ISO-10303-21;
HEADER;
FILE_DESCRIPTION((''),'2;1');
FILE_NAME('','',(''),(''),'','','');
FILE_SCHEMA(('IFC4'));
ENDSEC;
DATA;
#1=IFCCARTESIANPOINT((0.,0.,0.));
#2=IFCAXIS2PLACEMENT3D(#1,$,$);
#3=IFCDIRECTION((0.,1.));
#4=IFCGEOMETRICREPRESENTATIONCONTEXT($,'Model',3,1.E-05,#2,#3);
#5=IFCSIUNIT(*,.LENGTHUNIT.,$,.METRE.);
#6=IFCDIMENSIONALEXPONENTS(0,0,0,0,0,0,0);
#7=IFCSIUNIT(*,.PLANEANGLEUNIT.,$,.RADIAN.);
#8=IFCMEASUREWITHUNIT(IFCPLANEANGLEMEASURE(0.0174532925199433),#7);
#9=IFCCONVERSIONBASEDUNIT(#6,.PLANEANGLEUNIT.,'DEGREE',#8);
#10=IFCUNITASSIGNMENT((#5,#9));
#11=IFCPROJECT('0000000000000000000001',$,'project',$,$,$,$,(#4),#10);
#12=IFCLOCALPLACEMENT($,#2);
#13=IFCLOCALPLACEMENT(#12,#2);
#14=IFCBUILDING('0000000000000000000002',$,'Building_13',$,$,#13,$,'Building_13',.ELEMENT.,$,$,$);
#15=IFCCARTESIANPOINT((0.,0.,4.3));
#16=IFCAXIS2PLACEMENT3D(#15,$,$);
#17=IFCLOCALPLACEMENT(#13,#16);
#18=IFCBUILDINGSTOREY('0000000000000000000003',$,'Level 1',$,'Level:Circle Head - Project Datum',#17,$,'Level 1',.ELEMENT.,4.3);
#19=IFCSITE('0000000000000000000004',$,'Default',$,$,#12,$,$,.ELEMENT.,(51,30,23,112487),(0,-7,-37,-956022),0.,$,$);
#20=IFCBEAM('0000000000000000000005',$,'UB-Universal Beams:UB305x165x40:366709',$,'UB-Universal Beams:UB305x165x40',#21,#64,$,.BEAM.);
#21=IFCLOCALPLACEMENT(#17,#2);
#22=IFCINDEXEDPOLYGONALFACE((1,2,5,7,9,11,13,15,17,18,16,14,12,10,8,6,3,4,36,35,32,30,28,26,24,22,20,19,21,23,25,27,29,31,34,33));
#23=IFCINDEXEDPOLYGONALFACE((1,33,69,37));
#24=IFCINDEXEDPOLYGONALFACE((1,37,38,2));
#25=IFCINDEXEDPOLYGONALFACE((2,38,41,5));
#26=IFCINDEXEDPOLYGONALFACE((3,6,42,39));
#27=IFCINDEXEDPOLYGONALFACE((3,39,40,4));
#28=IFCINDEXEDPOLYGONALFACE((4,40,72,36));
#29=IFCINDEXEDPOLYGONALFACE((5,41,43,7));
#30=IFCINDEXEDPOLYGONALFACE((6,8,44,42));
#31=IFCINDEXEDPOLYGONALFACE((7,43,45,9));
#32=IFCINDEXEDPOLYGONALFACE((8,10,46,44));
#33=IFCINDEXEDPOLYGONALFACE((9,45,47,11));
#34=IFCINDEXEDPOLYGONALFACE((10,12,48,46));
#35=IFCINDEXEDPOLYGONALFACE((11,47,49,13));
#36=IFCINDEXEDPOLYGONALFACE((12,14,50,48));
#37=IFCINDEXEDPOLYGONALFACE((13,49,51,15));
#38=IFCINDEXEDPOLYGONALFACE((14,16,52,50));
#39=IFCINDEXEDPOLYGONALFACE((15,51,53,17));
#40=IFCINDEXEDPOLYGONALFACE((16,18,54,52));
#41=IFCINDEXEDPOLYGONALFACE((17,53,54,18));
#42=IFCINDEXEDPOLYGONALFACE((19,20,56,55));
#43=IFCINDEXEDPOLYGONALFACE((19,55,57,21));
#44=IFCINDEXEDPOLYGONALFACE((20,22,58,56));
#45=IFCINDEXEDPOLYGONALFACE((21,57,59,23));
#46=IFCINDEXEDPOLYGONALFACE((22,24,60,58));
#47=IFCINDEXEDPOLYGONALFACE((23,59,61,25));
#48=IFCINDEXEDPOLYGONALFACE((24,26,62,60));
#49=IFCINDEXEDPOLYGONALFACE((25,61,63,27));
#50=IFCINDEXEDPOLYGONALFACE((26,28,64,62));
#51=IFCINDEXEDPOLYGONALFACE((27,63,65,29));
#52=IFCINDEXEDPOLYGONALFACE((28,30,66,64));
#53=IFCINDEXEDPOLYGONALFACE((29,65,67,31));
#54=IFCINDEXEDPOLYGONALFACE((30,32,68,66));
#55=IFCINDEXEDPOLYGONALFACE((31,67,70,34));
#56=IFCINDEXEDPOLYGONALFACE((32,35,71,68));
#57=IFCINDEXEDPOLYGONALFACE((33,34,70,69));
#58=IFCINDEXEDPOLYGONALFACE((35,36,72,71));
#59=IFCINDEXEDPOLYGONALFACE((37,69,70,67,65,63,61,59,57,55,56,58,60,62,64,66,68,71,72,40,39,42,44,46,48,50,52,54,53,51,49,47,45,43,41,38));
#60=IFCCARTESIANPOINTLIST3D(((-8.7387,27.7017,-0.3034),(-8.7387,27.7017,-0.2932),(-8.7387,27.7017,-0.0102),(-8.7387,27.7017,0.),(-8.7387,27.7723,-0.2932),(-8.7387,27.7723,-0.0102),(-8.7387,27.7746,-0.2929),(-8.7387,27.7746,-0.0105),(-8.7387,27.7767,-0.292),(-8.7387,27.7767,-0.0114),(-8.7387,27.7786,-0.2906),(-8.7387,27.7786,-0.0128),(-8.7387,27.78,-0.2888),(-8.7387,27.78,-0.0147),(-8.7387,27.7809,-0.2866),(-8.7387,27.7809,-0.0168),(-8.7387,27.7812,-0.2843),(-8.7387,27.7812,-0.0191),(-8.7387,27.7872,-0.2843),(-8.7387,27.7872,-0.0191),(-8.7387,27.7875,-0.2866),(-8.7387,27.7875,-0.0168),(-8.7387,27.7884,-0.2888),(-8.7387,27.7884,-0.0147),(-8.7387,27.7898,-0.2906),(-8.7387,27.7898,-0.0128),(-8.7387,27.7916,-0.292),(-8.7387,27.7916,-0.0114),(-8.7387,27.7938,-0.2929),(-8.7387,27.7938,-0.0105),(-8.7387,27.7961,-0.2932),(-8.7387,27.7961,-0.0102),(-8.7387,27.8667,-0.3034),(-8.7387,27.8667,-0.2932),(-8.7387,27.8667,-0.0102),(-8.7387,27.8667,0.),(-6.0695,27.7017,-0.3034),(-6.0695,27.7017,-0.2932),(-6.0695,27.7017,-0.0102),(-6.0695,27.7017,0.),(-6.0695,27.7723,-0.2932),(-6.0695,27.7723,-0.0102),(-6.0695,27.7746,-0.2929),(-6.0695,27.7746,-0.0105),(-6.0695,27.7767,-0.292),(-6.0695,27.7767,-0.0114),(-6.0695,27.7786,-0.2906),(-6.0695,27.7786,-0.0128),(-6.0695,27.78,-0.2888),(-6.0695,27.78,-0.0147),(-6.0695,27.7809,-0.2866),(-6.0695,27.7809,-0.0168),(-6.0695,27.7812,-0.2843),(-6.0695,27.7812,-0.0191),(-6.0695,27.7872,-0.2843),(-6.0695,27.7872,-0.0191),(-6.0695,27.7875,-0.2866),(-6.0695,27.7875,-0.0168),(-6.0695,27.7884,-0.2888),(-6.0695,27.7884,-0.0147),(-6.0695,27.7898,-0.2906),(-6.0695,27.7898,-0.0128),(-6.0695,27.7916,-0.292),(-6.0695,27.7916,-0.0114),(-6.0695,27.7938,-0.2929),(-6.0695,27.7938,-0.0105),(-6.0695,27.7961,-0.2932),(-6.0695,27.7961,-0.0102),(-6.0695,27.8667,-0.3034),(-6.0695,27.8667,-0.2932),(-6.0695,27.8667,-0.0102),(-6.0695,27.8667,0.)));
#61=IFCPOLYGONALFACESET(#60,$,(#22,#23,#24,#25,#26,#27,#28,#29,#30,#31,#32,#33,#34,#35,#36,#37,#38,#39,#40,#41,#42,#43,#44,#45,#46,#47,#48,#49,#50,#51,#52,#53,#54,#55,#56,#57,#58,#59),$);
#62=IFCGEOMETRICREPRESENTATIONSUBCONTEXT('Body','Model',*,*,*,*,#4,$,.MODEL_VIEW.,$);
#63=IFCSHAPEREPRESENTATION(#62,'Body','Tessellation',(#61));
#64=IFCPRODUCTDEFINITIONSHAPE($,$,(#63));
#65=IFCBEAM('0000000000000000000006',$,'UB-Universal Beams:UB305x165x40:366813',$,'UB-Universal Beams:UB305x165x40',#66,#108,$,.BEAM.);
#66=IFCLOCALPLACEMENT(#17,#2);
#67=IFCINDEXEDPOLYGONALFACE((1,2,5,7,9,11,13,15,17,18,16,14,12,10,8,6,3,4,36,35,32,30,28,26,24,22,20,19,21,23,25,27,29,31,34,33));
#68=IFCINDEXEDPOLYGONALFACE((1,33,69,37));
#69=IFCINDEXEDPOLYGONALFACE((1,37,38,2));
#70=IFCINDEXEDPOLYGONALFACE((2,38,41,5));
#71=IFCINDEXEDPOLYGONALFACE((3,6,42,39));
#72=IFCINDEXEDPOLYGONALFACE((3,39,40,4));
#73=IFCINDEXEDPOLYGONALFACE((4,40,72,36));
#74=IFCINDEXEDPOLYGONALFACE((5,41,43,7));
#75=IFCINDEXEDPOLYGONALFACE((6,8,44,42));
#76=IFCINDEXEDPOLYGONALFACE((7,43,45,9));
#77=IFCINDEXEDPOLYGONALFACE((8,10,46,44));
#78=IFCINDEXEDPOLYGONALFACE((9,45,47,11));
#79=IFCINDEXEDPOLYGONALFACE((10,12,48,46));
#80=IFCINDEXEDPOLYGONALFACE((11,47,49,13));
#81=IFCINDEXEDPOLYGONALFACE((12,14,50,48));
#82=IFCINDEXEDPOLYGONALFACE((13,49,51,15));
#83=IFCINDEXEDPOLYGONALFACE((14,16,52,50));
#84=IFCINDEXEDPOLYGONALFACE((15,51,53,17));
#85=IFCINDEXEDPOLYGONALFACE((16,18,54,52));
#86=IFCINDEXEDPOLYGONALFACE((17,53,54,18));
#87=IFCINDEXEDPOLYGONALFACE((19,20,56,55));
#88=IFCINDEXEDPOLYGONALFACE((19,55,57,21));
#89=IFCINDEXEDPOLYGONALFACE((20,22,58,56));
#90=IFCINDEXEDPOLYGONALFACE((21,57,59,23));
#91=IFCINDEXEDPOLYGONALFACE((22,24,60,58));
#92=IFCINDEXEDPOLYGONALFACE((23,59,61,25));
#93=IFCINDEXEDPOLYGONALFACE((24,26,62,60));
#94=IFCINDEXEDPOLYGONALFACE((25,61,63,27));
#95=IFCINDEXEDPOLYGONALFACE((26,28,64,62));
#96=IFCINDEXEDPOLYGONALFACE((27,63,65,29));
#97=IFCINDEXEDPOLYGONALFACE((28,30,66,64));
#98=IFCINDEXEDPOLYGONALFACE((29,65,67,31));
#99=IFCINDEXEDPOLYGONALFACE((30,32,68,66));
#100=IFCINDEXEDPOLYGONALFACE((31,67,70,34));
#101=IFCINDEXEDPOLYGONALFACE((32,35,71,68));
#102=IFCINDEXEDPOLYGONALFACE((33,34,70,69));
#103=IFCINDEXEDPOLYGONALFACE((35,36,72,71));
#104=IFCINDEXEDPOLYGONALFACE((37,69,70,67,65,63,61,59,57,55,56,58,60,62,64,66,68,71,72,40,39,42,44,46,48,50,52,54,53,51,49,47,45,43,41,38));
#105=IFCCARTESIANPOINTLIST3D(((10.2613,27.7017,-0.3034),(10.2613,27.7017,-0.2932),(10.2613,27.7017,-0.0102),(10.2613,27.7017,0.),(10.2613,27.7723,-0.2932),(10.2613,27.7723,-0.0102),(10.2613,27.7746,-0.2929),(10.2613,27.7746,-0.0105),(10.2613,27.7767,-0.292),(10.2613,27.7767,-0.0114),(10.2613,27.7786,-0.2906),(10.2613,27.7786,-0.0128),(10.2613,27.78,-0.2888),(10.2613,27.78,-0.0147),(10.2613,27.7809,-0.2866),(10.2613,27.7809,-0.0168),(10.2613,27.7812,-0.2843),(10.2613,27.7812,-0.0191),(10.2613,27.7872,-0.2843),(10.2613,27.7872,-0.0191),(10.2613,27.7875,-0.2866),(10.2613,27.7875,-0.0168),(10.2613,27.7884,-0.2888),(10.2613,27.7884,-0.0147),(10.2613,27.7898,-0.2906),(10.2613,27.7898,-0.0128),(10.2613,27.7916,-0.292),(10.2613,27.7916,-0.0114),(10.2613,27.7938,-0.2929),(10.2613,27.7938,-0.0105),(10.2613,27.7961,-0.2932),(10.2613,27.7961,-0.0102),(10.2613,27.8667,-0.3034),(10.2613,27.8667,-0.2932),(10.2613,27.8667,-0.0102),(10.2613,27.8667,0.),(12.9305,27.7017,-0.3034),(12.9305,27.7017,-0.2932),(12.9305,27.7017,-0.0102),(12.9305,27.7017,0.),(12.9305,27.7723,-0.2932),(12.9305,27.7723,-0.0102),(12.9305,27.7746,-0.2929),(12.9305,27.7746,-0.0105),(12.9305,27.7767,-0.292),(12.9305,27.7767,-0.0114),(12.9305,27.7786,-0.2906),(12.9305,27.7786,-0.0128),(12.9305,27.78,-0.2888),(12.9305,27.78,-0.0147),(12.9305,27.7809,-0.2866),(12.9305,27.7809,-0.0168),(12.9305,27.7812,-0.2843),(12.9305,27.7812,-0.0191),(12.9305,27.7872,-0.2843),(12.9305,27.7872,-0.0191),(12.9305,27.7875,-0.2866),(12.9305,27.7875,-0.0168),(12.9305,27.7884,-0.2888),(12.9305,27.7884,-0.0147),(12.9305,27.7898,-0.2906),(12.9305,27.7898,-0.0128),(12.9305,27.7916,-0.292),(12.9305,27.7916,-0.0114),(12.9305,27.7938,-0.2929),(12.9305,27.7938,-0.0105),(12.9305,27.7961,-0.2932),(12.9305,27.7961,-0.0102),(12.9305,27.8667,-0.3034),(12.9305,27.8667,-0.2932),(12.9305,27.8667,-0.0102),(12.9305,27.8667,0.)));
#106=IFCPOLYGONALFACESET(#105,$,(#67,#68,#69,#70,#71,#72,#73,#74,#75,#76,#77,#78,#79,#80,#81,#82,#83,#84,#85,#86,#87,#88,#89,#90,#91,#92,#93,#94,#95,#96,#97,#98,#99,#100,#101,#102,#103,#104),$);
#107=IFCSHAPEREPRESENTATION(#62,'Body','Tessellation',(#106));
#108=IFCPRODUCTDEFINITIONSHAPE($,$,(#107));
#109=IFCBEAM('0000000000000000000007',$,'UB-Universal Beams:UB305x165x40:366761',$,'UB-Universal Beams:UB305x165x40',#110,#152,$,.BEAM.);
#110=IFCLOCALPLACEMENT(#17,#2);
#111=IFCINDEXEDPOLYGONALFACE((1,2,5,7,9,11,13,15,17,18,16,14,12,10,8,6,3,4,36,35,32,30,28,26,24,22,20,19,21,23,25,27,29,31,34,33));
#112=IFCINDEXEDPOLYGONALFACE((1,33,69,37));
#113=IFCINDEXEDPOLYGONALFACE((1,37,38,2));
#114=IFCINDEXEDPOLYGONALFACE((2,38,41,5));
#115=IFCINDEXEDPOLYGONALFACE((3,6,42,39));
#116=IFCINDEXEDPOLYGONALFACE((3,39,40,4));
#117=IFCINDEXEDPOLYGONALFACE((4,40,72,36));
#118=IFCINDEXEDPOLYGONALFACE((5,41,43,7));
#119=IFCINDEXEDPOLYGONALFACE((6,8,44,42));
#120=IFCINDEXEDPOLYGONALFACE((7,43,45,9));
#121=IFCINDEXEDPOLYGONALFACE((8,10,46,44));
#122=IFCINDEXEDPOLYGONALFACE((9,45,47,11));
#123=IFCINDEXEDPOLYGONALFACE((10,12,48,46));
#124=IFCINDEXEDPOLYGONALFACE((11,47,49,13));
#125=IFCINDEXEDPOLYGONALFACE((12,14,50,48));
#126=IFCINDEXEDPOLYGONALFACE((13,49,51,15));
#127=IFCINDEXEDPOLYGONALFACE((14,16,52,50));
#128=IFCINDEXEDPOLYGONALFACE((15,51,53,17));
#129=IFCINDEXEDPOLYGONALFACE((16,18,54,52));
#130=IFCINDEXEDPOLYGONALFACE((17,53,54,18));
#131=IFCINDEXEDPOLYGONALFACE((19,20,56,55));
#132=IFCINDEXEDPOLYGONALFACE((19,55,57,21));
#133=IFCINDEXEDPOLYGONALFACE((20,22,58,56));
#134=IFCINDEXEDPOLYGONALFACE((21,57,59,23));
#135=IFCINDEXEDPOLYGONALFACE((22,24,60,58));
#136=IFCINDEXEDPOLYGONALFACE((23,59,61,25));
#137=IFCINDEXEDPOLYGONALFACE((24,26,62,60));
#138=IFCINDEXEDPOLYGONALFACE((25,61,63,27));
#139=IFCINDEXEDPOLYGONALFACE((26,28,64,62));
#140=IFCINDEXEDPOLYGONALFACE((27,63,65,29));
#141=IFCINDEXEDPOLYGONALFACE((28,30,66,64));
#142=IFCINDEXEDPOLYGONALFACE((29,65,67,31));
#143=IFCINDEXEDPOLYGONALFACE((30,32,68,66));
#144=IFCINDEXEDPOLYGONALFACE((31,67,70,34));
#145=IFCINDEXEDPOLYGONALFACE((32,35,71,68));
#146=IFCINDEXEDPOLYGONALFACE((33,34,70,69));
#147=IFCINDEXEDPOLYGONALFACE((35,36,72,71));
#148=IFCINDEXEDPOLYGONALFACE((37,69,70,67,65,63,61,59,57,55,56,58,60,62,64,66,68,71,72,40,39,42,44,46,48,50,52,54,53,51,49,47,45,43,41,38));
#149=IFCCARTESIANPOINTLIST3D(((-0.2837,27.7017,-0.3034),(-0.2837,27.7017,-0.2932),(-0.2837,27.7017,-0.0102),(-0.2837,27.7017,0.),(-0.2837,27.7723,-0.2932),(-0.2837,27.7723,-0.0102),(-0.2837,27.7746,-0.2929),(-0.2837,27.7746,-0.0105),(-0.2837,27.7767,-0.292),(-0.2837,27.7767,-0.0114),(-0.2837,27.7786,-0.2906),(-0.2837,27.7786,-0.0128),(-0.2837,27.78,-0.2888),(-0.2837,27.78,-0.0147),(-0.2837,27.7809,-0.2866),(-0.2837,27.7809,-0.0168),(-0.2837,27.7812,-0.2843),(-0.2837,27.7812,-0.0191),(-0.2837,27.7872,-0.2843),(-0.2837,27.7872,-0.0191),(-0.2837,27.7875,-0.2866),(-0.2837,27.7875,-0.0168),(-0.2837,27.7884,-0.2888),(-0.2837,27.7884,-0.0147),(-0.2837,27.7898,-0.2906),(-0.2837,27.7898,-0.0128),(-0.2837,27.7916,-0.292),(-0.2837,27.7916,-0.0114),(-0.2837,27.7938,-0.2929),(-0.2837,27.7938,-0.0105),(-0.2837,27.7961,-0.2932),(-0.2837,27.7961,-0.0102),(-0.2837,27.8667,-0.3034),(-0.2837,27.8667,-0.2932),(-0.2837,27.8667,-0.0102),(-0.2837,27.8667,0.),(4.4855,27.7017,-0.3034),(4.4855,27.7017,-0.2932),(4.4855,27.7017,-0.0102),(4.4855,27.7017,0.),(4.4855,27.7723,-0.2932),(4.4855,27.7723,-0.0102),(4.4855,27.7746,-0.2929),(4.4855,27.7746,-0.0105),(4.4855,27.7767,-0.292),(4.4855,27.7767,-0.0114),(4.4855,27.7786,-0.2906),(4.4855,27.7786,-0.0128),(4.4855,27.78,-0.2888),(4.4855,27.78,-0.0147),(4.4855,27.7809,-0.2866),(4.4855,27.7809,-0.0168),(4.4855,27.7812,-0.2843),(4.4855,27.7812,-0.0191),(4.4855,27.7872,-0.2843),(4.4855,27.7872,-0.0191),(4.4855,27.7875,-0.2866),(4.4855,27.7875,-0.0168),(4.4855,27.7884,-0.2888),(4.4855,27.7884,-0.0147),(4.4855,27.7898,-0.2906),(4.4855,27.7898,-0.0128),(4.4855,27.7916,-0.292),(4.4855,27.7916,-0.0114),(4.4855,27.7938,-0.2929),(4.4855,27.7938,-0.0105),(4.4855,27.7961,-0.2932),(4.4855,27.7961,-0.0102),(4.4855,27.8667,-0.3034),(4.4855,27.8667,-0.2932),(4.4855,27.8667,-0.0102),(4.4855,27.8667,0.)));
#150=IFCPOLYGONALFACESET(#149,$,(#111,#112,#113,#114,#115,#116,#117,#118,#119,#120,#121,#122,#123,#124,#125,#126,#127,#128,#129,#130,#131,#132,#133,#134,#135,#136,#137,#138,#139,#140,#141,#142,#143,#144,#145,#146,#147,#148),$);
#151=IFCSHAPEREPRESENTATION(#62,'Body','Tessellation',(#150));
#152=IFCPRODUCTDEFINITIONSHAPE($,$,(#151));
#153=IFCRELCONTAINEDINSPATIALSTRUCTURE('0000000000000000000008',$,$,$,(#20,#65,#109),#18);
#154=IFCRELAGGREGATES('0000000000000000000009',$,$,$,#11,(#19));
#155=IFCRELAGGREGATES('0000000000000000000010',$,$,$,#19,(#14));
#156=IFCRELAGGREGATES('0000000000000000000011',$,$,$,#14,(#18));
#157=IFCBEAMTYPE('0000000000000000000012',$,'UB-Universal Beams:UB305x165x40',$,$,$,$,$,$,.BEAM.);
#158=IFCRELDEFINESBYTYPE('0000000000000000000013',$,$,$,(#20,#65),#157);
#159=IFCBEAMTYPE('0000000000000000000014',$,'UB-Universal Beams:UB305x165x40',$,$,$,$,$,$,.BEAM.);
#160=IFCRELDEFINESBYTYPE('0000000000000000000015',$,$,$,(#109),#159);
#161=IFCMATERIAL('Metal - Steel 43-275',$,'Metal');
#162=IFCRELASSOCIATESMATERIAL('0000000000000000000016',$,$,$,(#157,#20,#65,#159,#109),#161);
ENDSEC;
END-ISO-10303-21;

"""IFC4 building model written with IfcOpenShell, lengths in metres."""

from ifc_helpers import new_model, entity, si_unit, converted_unit, direction, frame, origin, place, context, subcontext, project, spatial, line, arc, indexed_curve, outline, extrude, source, transform, mapped, material, type_object, type_shapes, element, save


model = new_model("IFC4")

# Units and contexts
model_context = context("Model", 3, precision=1e-05, world=origin(), true_north=direction((0.0, 1.0)))
body_context = subcontext(model_context, "Body", "Model", "MODEL_VIEW")
ifc_project = project(units=[si_unit("LENGTHUNIT", "METRE"), converted_unit("PLANEANGLEUNIT", "DEGREE", entity("IfcPlaneAngleMeasure", 0.0174532925199433), si_unit("PLANEANGLEUNIT", "RADIAN"), dimensions=[0, 0, 0, 0, 0, 0, 0])], contexts=[model_context])

# Site, building, storey
site_placement = place(None, origin())
site = spatial("IfcSite", under=ifc_project, at=site_placement, Name="Default", CompositionType="ELEMENT", RefLatitude=(51, 30, 23, 112487), RefLongitude=(0, -7, -37, -956022), RefElevation=0.0)
building_placement = place(site_placement, origin())
building = spatial("IfcBuilding", under=site, at=building_placement, Name="Building_13", LongName="Building_13", CompositionType="ELEMENT")
storey_placement = place(building_placement, frame((0.0, 0.0, 4.3)))
storey = spatial("IfcBuildingStorey", under=building, at=storey_placement, Name="Level 1", ObjectType="Level:Circle Head - Project Datum", LongName="Level 1", CompositionType="ELEMENT", Elevation=4.3)

# Beams
ifc_material_1 = material(Name="Metal - Steel 43-275", Category="Metal")
beam_type_1 = type_object("IfcBeamType", Name="UB-Universal Beams:UB305x165x40", PredefinedType="BEAM", material=ifc_material_1)
shared_shape_1 = source(origin(), body_context, "Body", "SweptSolid", [
    extrude(outline(indexed_curve([(-0.0825, -0.1415), (-0.0825, -0.1517), (0.0825, -0.1517), (0.0825, -0.1415), (0.0119, -0.1415), (0.0056, -0.1389), (0.003, -0.1326), (0.003, 0.1326), (0.0056, 0.1389), (0.0119, 0.1415), (0.0825, 0.1415), (0.0825, 0.1517), (-0.0825, 0.1517), (-0.0825, 0.1415), (-0.0119, 0.1415), (-0.0056, 0.1389), (-0.003, 0.1326), (-0.003, -0.1326), (-0.0056, -0.1389), (-0.0119, -0.1415)], segments=[line(1, 2, 3, 4, 5), arc(5, 6, 7), line(7, 8), arc(8, 9, 10), line(10, 11, 12, 13, 14, 15), arc(15, 16, 17), line(17, 18), arc(18, 19, 20), line(20, 1)], self_intersect=False)), frame((-1.3346, 0.0, 0.0), z_axis=(-1.0, 0.0, 0.0), x_axis=(0.0, -1.0, 0.0)), (0.0, 0.0, -1.0), 2.6692),
])
type_shapes(beam_type_1, [shared_shape_1])
for number, where, name in (
    (1, (-7.4041, 27.7842, -0.1517), "UB-Universal Beams:UB305x165x40:366709"),
    (2, (11.5959, 27.7842, -0.1517), "UB-Universal Beams:UB305x165x40:366813"),
):
    element("IfcBeam", number, at=place(storey_placement, frame(where)), inside=storey, type_object=beam_type_1, material=ifc_material_1, Name=name, ObjectType="UB-Universal Beams:UB305x165x40", PredefinedType="BEAM", context=body_context, shape_type="MappedRepresentation", body=[
        mapped(shared_shape_1, transform((0.0, 0.0, 0.0), scale=1.0)),
    ])
beam_type_2 = type_object("IfcBeamType", Name="UB-Universal Beams:UB305x165x40", PredefinedType="BEAM", material=ifc_material_1)
shared_shape_2 = source(origin(), body_context, "Body", "SweptSolid", [
    extrude(outline(indexed_curve([(-0.0825, -0.1415), (-0.0825, -0.1517), (0.0825, -0.1517), (0.0825, -0.1415), (0.0119, -0.1415), (0.0056, -0.1389), (0.003, -0.1326), (0.003, 0.1326), (0.0056, 0.1389), (0.0119, 0.1415), (0.0825, 0.1415), (0.0825, 0.1517), (-0.0825, 0.1517), (-0.0825, 0.1415), (-0.0119, 0.1415), (-0.0056, 0.1389), (-0.003, 0.1326), (-0.003, -0.1326), (-0.0056, -0.1389), (-0.0119, -0.1415)], segments=[line(1, 2, 3, 4, 5), arc(5, 6, 7), line(7, 8), arc(8, 9, 10), line(10, 11, 12, 13, 14, 15), arc(15, 16, 17), line(17, 18), arc(18, 19, 20), line(20, 1)], self_intersect=False)), frame((-2.3846, 0.0, 0.0), z_axis=(-1.0, 0.0, 0.0), x_axis=(0.0, -1.0, 0.0)), (0.0, 0.0, -1.0), 4.7692),
])
type_shapes(beam_type_2, [shared_shape_2])
beam_1_placement = place(storey_placement, frame((2.1009, 27.7842, -0.1517)))
element("IfcBeam", 3, at=beam_1_placement, inside=storey, type_object=beam_type_2, material=ifc_material_1, Name="UB-Universal Beams:UB305x165x40:366761", ObjectType="UB-Universal Beams:UB305x165x40", PredefinedType="BEAM", context=body_context, shape_type="MappedRepresentation", body=[
    mapped(shared_shape_2, transform((0.0, 0.0, 0.0), scale=1.0)),
])

save(model, "model.ifc")
